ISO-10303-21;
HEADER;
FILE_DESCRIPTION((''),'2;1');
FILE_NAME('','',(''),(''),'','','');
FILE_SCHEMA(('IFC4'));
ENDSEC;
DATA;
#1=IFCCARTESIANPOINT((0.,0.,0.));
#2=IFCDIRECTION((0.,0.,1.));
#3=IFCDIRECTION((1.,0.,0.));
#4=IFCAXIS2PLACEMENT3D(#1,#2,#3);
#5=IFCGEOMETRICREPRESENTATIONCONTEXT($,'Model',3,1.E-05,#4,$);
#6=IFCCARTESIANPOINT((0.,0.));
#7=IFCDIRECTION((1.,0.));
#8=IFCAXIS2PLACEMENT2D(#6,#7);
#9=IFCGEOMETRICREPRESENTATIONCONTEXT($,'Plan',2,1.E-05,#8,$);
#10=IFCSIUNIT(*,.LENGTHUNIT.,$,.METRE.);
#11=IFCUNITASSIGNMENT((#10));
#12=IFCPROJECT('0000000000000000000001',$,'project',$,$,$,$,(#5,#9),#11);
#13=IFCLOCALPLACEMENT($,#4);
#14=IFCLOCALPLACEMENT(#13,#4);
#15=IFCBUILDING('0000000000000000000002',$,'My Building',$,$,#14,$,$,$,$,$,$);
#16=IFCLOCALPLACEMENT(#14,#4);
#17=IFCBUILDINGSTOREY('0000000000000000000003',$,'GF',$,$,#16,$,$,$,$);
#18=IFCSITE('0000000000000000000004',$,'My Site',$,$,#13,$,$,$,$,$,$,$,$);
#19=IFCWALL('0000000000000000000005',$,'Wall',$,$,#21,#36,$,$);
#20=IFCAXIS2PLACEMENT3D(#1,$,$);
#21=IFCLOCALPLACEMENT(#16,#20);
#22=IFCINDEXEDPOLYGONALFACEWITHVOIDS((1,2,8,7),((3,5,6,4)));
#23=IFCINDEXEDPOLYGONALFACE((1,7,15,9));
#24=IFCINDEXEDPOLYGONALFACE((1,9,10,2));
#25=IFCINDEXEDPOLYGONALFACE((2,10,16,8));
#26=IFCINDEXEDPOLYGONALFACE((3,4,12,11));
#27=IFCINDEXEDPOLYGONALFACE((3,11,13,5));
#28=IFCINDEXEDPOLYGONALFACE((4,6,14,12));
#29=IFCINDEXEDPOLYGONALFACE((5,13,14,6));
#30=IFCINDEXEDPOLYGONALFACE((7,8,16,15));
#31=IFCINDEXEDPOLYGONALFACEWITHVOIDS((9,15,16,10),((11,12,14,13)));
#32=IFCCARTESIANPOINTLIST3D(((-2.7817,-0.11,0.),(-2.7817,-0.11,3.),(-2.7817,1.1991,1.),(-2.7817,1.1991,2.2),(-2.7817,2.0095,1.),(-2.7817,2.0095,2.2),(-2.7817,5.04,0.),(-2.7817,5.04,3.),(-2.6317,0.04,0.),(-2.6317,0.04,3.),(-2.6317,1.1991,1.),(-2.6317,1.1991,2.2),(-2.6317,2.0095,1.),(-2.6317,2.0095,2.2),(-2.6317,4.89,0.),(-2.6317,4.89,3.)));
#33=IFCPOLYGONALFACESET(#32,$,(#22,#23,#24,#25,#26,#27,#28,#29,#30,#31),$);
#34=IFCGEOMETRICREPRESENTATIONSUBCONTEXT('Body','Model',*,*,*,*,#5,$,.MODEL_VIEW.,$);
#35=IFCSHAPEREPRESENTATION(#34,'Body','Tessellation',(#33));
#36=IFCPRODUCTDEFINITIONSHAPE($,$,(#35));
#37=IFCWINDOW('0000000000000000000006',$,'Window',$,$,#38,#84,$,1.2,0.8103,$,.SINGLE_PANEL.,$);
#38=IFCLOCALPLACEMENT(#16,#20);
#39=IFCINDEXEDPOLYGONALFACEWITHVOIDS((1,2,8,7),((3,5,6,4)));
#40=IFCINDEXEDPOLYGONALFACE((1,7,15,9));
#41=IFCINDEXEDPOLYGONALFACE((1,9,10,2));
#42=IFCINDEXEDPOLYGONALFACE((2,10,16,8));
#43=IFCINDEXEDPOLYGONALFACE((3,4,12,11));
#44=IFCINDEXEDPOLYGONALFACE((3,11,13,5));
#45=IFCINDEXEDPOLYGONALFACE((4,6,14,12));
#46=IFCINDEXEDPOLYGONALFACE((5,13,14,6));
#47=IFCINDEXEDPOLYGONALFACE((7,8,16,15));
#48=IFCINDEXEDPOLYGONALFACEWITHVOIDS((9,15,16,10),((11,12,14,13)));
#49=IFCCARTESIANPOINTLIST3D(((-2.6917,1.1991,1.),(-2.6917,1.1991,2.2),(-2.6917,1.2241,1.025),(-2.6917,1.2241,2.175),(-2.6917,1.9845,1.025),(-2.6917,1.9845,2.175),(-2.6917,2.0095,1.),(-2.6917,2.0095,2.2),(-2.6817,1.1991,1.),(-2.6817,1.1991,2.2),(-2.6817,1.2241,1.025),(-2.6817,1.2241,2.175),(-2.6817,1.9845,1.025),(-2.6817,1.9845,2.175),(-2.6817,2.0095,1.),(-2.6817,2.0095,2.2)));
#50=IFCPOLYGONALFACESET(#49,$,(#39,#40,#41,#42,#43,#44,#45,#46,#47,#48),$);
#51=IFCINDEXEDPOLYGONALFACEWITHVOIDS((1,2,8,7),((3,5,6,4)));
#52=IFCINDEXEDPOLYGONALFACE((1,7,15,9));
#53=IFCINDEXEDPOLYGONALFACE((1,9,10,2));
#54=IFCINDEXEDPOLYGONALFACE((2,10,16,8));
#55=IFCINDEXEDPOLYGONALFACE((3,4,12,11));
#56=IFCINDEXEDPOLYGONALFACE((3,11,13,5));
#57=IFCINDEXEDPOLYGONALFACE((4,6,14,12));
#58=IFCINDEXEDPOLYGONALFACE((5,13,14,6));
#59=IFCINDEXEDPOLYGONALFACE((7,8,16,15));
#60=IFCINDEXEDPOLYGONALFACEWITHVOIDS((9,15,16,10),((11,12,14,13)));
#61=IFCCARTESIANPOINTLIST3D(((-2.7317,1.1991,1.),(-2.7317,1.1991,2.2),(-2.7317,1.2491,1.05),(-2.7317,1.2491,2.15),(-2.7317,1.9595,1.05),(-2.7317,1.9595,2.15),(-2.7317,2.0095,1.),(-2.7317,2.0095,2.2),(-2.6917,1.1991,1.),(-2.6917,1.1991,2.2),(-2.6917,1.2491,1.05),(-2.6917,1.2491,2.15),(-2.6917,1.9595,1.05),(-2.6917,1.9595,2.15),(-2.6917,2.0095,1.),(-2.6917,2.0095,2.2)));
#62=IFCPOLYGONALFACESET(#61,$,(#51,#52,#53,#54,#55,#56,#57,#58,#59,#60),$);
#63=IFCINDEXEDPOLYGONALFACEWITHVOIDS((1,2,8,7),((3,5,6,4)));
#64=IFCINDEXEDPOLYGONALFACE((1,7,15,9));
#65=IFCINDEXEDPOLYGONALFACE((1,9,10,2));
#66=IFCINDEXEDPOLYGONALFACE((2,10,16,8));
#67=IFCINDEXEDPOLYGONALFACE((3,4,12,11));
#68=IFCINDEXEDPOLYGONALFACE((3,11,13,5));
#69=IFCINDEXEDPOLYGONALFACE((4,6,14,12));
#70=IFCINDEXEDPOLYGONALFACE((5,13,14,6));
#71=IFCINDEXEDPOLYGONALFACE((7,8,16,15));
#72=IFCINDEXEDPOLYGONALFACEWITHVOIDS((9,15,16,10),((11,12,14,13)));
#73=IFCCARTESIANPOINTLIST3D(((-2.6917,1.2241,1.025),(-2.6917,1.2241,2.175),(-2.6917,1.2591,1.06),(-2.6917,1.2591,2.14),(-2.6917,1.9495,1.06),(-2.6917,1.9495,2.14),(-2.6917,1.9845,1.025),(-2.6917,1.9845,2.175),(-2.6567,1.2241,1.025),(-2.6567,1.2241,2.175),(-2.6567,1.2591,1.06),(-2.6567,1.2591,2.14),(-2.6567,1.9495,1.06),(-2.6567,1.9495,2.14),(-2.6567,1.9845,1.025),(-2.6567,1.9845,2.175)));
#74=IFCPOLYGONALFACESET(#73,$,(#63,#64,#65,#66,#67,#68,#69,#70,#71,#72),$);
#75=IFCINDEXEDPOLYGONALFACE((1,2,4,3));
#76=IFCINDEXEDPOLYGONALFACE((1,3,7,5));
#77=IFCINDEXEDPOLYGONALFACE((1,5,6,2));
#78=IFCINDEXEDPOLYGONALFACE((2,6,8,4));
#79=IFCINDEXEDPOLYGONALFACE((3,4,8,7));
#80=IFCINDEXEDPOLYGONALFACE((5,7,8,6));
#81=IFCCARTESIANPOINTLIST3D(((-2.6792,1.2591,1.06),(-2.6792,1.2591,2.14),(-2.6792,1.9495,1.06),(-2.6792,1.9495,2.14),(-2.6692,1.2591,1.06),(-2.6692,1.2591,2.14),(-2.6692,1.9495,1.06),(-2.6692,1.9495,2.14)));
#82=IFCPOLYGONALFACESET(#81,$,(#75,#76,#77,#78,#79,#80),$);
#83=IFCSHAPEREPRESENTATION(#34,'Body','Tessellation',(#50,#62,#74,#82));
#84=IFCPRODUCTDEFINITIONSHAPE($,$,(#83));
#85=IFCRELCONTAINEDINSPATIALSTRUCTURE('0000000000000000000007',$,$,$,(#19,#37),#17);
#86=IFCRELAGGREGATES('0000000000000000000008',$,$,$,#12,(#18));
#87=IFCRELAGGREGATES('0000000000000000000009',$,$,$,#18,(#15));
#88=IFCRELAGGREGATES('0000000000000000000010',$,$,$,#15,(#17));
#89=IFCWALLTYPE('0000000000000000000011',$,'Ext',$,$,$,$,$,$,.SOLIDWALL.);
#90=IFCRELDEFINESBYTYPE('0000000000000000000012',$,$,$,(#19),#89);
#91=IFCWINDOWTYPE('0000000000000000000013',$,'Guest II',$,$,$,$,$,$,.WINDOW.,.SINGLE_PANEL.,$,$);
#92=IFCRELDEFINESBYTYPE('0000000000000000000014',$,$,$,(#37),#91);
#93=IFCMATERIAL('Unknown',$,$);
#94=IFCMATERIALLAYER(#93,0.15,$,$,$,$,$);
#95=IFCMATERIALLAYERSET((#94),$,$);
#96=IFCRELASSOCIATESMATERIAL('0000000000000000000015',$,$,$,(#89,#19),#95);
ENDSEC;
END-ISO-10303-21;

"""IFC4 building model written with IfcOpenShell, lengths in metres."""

from ifc_helpers import new_model, entity, si_unit, frame, origin_with_axes, origin_2d_with_axis, place, context, subcontext, project, spatial, line, indexed_curve, outline, extrude, shape, source, transform, mapped, material, layer, layer_set, layer_usage, type_object, type_shapes, element, fill, save


model = new_model("IFC4")

# Units and contexts
model_context = context("Model", 3, precision=1e-05, world=origin_with_axes())
plan_context = context("Plan", 2, precision=1e-05, world=origin_2d_with_axis())
body_context_1 = subcontext(model_context, "Body", "Model", "MODEL_VIEW")
body_context_2 = subcontext(plan_context, "Body", "Plan", "PLAN_VIEW")
ifc_project = project(units=[si_unit("LENGTHUNIT", "METRE")], contexts=[model_context, plan_context])

# Site, building, storey
site_placement = place(None, origin_with_axes())
site = spatial("IfcSite", under=ifc_project, at=site_placement, Name="My Site")
building_placement = place(site_placement, origin_with_axes())
building = spatial("IfcBuilding", under=site, at=building_placement, Name="My Building")
storey_placement = place(building_placement, origin_with_axes())
storey = spatial("IfcBuildingStorey", under=building, at=storey_placement, Name="GF")

# Shared definitions
ifc_material = material(Name="Unknown")

# Shared definitions
ifc_layer_1 = layer(ifc_material, 0.15)
ifc_layer_set_1 = layer_set([ifc_layer_1])
wall_type_1 = type_object("IfcWallType", Name="Ext", PredefinedType="SOLIDWALL", material=ifc_layer_set_1)

# Wall, opening, window
ifc_layer_usage_1 = layer_usage(ifc_layer_set_1, "AXIS2", "POSITIVE", 0.0)
wall_1_placement = place(storey_placement, frame((-2.7817, 5.04, 0.0), z_axis=(0.0, 0.0, 1.0), x_axis=(0.0, -1.0, 0.0)))
wall_1 = element("IfcWall", 1, at=wall_1_placement, inside=storey, type_object=wall_type_1, material=ifc_layer_usage_1, Name="Wall", context=body_context_1, shape_type="SweptSolid", body=[
    extrude(outline(indexed_curve([(0.0, 0.0), (0.15, 0.15), (5.0, 0.15), (5.15, 0.0)], segments=[line(1, 2, 3, 4, 1)])), origin_with_axes(), (0.0, 0.0, 1.0), 3.0),
])
shared_shape_1 = source(origin_with_axes(), body_context_1, "Body", "SweptSolid", [
    extrude(outline(indexed_curve([(0.0, 0.0), (0.8103, 0.0), (0.8103, 1.2), (0.0, 1.2)], segments=[line(1, 2, 3, 4, 1)])), frame((0.0, -0.6, 0.0), z_axis=(0.0, -1.0, 0.0), x_axis=(1.0, 0.0, 0.0)), (0.0, 0.0, -1.0), 1.2),
])
opening_1_placement = place(wall_1_placement, frame((3.0305, 0.0, 1.0), z_axis=(0.0, 0.0, 1.0), x_axis=(1.0, 0.0, 0.0)))
opening_1 = element("IfcOpeningElement", 2, at=opening_1_placement, cuts=wall_1, PredefinedType="OPENING", context=body_context_1, shape_type="MappedRepresentation", body=[
    mapped(shared_shape_1, transform((0.0, 0.0, 0.0), x_axis=(1.0, 0.0, 0.0), y_axis=(0.0, 1.0, 0.0), z_axis=(0.0, 0.0, 1.0), scale=1.0)),
])
window_type_1 = type_object("IfcWindowType", Name="Guest II", PartitioningType="SINGLE_PANEL", PredefinedType="WINDOW")
shared_shape_2 = source(origin_with_axes(), body_context_1, "Body", "SweptSolid", [
    extrude(outline(indexed_curve([(0.0, 0.0), (0.8103, 0.0), (0.8103, 1.2), (0.0, 1.2)], segments=[line(1, 2, 3, 4, 1)]), holes=[indexed_curve([(0.025, 0.025), (0.7853, 0.025), (0.7853, 1.175), (0.025, 1.175)], segments=[line(1, 2, 3, 4, 1)])]), frame((0.0, 0.09, 0.0), z_axis=(0.0, -1.0, 0.0), x_axis=(1.0, 0.0, 0.0)), (0.0, 0.0, -1.0), 0.01),
    extrude(outline(indexed_curve([(0.0, 0.0), (0.8103, 0.0), (0.8103, 1.2), (0.0, 1.2)], segments=[line(1, 2, 3, 4, 1)]), holes=[indexed_curve([(0.05, 0.05), (0.7603, 0.05), (0.7603, 1.15), (0.05, 1.15)], segments=[line(1, 2, 3, 4, 1)])]), frame((0.0, 0.05, 0.0), z_axis=(0.0, -1.0, 0.0), x_axis=(1.0, 0.0, 0.0)), (0.0, 0.0, -1.0), 0.04),
    extrude(outline(indexed_curve([(0.0, 0.0), (0.7603, 0.0), (0.7603, 1.15), (0.0, 1.15)], segments=[line(1, 2, 3, 4, 1)]), holes=[indexed_curve([(0.035, 0.035), (0.7253, 0.035), (0.7253, 1.115), (0.035, 1.115)], segments=[line(1, 2, 3, 4, 1)])]), frame((0.025, 0.09, 0.025), z_axis=(0.0, -1.0, 0.0), x_axis=(1.0, 0.0, 0.0)), (0.0, 0.0, -1.0), 0.035),
    extrude(outline(indexed_curve([(0.035, 0.035), (0.7253, 0.035), (0.7253, 1.115), (0.035, 1.115)], segments=[line(1, 2, 3, 4, 1)])), frame((0.025, 0.1025, 0.025), z_axis=(0.0, -1.0, 0.0), x_axis=(1.0, 0.0, 0.0)), (0.0, 0.0, -1.0), 0.01),
])
shared_shape_3 = source(origin_with_axes(), body_context_2, "Body", "Curve2D", [
    entity("IfcIndexedPolyCurve", entity("IfcCartesianPointList2D", [[0.05, 0.05], [0.7603, 0.05]])),
    entity("IfcIndexedPolyCurve", entity("IfcCartesianPointList2D", [[0.0, 0.1], [0.025, 0.1], [0.025, 0.09], [0.05, 0.09], [0.05, 0.05], [0.0, 0.05]]), [entity("IfcLineIndex", [1, 2, 3, 4, 5, 6, 1])]),
    entity("IfcIndexedPolyCurve", entity("IfcCartesianPointList2D", [[0.8103, 0.1], [0.7853, 0.1], [0.7853, 0.09], [0.7603, 0.09], [0.7603, 0.05], [0.8103, 0.05]]), [entity("IfcLineIndex", [1, 2, 3, 4, 5, 6, 1])]),
    entity("IfcIndexedPolyCurve", entity("IfcCartesianPointList2D", [[0.025, 0.09], [0.06, 0.09], [0.06, 0.125], [0.025, 0.125]]), [entity("IfcLineIndex", [1, 2, 3, 4, 1])]),
    entity("IfcIndexedPolyCurve", entity("IfcCartesianPointList2D", [[0.7853, 0.09], [0.7503, 0.09], [0.7503, 0.125], [0.7853, 0.125]]), [entity("IfcLineIndex", [1, 2, 3, 4, 1])]),
    entity("IfcIndexedPolyCurve", entity("IfcCartesianPointList2D", [[0.06, 0.09], [0.7503, 0.09]])),
    entity("IfcIndexedPolyCurve", entity("IfcCartesianPointList2D", [[0.06, 0.125], [0.7503, 0.125]])),
    entity("IfcIndexedPolyCurve", entity("IfcCartesianPointList2D", [[0.06, 0.1075], [0.7503, 0.1075]])),
])
type_shapes(window_type_1, [shared_shape_2, shared_shape_3])
window_1_placement = place(opening_1_placement, frame((0.0, 0.0, 0.0), z_axis=(0.0, 0.0, 1.0), x_axis=(1.0, 0.0, 0.0)))
window_1 = element("IfcWindow", 3, at=window_1_placement, inside=storey, type_object=window_type_1, Name="Window", OverallHeight=1.2, OverallWidth=0.8103, PartitioningType="SINGLE_PANEL", shapes=[
    shape(body_context_1, "Body", "MappedRepresentation", [mapped(shared_shape_2, transform((0.0, 0.0, 0.0), x_axis=(1.0, 0.0, 0.0), y_axis=(0.0, 1.0, 0.0), z_axis=(0.0, 0.0, 1.0), scale=1.0))]),
    shape(body_context_2, "Body", "MappedRepresentation", [mapped(shared_shape_3, transform((0.0, 0.0, 0.0), x_axis=(1.0, 0.0, 0.0), y_axis=(0.0, 1.0, 0.0), z_axis=(0.0, 0.0, 1.0), scale=1.0))]),
])
fill(opening_1, window_1)

save(model, "model.ifc")
